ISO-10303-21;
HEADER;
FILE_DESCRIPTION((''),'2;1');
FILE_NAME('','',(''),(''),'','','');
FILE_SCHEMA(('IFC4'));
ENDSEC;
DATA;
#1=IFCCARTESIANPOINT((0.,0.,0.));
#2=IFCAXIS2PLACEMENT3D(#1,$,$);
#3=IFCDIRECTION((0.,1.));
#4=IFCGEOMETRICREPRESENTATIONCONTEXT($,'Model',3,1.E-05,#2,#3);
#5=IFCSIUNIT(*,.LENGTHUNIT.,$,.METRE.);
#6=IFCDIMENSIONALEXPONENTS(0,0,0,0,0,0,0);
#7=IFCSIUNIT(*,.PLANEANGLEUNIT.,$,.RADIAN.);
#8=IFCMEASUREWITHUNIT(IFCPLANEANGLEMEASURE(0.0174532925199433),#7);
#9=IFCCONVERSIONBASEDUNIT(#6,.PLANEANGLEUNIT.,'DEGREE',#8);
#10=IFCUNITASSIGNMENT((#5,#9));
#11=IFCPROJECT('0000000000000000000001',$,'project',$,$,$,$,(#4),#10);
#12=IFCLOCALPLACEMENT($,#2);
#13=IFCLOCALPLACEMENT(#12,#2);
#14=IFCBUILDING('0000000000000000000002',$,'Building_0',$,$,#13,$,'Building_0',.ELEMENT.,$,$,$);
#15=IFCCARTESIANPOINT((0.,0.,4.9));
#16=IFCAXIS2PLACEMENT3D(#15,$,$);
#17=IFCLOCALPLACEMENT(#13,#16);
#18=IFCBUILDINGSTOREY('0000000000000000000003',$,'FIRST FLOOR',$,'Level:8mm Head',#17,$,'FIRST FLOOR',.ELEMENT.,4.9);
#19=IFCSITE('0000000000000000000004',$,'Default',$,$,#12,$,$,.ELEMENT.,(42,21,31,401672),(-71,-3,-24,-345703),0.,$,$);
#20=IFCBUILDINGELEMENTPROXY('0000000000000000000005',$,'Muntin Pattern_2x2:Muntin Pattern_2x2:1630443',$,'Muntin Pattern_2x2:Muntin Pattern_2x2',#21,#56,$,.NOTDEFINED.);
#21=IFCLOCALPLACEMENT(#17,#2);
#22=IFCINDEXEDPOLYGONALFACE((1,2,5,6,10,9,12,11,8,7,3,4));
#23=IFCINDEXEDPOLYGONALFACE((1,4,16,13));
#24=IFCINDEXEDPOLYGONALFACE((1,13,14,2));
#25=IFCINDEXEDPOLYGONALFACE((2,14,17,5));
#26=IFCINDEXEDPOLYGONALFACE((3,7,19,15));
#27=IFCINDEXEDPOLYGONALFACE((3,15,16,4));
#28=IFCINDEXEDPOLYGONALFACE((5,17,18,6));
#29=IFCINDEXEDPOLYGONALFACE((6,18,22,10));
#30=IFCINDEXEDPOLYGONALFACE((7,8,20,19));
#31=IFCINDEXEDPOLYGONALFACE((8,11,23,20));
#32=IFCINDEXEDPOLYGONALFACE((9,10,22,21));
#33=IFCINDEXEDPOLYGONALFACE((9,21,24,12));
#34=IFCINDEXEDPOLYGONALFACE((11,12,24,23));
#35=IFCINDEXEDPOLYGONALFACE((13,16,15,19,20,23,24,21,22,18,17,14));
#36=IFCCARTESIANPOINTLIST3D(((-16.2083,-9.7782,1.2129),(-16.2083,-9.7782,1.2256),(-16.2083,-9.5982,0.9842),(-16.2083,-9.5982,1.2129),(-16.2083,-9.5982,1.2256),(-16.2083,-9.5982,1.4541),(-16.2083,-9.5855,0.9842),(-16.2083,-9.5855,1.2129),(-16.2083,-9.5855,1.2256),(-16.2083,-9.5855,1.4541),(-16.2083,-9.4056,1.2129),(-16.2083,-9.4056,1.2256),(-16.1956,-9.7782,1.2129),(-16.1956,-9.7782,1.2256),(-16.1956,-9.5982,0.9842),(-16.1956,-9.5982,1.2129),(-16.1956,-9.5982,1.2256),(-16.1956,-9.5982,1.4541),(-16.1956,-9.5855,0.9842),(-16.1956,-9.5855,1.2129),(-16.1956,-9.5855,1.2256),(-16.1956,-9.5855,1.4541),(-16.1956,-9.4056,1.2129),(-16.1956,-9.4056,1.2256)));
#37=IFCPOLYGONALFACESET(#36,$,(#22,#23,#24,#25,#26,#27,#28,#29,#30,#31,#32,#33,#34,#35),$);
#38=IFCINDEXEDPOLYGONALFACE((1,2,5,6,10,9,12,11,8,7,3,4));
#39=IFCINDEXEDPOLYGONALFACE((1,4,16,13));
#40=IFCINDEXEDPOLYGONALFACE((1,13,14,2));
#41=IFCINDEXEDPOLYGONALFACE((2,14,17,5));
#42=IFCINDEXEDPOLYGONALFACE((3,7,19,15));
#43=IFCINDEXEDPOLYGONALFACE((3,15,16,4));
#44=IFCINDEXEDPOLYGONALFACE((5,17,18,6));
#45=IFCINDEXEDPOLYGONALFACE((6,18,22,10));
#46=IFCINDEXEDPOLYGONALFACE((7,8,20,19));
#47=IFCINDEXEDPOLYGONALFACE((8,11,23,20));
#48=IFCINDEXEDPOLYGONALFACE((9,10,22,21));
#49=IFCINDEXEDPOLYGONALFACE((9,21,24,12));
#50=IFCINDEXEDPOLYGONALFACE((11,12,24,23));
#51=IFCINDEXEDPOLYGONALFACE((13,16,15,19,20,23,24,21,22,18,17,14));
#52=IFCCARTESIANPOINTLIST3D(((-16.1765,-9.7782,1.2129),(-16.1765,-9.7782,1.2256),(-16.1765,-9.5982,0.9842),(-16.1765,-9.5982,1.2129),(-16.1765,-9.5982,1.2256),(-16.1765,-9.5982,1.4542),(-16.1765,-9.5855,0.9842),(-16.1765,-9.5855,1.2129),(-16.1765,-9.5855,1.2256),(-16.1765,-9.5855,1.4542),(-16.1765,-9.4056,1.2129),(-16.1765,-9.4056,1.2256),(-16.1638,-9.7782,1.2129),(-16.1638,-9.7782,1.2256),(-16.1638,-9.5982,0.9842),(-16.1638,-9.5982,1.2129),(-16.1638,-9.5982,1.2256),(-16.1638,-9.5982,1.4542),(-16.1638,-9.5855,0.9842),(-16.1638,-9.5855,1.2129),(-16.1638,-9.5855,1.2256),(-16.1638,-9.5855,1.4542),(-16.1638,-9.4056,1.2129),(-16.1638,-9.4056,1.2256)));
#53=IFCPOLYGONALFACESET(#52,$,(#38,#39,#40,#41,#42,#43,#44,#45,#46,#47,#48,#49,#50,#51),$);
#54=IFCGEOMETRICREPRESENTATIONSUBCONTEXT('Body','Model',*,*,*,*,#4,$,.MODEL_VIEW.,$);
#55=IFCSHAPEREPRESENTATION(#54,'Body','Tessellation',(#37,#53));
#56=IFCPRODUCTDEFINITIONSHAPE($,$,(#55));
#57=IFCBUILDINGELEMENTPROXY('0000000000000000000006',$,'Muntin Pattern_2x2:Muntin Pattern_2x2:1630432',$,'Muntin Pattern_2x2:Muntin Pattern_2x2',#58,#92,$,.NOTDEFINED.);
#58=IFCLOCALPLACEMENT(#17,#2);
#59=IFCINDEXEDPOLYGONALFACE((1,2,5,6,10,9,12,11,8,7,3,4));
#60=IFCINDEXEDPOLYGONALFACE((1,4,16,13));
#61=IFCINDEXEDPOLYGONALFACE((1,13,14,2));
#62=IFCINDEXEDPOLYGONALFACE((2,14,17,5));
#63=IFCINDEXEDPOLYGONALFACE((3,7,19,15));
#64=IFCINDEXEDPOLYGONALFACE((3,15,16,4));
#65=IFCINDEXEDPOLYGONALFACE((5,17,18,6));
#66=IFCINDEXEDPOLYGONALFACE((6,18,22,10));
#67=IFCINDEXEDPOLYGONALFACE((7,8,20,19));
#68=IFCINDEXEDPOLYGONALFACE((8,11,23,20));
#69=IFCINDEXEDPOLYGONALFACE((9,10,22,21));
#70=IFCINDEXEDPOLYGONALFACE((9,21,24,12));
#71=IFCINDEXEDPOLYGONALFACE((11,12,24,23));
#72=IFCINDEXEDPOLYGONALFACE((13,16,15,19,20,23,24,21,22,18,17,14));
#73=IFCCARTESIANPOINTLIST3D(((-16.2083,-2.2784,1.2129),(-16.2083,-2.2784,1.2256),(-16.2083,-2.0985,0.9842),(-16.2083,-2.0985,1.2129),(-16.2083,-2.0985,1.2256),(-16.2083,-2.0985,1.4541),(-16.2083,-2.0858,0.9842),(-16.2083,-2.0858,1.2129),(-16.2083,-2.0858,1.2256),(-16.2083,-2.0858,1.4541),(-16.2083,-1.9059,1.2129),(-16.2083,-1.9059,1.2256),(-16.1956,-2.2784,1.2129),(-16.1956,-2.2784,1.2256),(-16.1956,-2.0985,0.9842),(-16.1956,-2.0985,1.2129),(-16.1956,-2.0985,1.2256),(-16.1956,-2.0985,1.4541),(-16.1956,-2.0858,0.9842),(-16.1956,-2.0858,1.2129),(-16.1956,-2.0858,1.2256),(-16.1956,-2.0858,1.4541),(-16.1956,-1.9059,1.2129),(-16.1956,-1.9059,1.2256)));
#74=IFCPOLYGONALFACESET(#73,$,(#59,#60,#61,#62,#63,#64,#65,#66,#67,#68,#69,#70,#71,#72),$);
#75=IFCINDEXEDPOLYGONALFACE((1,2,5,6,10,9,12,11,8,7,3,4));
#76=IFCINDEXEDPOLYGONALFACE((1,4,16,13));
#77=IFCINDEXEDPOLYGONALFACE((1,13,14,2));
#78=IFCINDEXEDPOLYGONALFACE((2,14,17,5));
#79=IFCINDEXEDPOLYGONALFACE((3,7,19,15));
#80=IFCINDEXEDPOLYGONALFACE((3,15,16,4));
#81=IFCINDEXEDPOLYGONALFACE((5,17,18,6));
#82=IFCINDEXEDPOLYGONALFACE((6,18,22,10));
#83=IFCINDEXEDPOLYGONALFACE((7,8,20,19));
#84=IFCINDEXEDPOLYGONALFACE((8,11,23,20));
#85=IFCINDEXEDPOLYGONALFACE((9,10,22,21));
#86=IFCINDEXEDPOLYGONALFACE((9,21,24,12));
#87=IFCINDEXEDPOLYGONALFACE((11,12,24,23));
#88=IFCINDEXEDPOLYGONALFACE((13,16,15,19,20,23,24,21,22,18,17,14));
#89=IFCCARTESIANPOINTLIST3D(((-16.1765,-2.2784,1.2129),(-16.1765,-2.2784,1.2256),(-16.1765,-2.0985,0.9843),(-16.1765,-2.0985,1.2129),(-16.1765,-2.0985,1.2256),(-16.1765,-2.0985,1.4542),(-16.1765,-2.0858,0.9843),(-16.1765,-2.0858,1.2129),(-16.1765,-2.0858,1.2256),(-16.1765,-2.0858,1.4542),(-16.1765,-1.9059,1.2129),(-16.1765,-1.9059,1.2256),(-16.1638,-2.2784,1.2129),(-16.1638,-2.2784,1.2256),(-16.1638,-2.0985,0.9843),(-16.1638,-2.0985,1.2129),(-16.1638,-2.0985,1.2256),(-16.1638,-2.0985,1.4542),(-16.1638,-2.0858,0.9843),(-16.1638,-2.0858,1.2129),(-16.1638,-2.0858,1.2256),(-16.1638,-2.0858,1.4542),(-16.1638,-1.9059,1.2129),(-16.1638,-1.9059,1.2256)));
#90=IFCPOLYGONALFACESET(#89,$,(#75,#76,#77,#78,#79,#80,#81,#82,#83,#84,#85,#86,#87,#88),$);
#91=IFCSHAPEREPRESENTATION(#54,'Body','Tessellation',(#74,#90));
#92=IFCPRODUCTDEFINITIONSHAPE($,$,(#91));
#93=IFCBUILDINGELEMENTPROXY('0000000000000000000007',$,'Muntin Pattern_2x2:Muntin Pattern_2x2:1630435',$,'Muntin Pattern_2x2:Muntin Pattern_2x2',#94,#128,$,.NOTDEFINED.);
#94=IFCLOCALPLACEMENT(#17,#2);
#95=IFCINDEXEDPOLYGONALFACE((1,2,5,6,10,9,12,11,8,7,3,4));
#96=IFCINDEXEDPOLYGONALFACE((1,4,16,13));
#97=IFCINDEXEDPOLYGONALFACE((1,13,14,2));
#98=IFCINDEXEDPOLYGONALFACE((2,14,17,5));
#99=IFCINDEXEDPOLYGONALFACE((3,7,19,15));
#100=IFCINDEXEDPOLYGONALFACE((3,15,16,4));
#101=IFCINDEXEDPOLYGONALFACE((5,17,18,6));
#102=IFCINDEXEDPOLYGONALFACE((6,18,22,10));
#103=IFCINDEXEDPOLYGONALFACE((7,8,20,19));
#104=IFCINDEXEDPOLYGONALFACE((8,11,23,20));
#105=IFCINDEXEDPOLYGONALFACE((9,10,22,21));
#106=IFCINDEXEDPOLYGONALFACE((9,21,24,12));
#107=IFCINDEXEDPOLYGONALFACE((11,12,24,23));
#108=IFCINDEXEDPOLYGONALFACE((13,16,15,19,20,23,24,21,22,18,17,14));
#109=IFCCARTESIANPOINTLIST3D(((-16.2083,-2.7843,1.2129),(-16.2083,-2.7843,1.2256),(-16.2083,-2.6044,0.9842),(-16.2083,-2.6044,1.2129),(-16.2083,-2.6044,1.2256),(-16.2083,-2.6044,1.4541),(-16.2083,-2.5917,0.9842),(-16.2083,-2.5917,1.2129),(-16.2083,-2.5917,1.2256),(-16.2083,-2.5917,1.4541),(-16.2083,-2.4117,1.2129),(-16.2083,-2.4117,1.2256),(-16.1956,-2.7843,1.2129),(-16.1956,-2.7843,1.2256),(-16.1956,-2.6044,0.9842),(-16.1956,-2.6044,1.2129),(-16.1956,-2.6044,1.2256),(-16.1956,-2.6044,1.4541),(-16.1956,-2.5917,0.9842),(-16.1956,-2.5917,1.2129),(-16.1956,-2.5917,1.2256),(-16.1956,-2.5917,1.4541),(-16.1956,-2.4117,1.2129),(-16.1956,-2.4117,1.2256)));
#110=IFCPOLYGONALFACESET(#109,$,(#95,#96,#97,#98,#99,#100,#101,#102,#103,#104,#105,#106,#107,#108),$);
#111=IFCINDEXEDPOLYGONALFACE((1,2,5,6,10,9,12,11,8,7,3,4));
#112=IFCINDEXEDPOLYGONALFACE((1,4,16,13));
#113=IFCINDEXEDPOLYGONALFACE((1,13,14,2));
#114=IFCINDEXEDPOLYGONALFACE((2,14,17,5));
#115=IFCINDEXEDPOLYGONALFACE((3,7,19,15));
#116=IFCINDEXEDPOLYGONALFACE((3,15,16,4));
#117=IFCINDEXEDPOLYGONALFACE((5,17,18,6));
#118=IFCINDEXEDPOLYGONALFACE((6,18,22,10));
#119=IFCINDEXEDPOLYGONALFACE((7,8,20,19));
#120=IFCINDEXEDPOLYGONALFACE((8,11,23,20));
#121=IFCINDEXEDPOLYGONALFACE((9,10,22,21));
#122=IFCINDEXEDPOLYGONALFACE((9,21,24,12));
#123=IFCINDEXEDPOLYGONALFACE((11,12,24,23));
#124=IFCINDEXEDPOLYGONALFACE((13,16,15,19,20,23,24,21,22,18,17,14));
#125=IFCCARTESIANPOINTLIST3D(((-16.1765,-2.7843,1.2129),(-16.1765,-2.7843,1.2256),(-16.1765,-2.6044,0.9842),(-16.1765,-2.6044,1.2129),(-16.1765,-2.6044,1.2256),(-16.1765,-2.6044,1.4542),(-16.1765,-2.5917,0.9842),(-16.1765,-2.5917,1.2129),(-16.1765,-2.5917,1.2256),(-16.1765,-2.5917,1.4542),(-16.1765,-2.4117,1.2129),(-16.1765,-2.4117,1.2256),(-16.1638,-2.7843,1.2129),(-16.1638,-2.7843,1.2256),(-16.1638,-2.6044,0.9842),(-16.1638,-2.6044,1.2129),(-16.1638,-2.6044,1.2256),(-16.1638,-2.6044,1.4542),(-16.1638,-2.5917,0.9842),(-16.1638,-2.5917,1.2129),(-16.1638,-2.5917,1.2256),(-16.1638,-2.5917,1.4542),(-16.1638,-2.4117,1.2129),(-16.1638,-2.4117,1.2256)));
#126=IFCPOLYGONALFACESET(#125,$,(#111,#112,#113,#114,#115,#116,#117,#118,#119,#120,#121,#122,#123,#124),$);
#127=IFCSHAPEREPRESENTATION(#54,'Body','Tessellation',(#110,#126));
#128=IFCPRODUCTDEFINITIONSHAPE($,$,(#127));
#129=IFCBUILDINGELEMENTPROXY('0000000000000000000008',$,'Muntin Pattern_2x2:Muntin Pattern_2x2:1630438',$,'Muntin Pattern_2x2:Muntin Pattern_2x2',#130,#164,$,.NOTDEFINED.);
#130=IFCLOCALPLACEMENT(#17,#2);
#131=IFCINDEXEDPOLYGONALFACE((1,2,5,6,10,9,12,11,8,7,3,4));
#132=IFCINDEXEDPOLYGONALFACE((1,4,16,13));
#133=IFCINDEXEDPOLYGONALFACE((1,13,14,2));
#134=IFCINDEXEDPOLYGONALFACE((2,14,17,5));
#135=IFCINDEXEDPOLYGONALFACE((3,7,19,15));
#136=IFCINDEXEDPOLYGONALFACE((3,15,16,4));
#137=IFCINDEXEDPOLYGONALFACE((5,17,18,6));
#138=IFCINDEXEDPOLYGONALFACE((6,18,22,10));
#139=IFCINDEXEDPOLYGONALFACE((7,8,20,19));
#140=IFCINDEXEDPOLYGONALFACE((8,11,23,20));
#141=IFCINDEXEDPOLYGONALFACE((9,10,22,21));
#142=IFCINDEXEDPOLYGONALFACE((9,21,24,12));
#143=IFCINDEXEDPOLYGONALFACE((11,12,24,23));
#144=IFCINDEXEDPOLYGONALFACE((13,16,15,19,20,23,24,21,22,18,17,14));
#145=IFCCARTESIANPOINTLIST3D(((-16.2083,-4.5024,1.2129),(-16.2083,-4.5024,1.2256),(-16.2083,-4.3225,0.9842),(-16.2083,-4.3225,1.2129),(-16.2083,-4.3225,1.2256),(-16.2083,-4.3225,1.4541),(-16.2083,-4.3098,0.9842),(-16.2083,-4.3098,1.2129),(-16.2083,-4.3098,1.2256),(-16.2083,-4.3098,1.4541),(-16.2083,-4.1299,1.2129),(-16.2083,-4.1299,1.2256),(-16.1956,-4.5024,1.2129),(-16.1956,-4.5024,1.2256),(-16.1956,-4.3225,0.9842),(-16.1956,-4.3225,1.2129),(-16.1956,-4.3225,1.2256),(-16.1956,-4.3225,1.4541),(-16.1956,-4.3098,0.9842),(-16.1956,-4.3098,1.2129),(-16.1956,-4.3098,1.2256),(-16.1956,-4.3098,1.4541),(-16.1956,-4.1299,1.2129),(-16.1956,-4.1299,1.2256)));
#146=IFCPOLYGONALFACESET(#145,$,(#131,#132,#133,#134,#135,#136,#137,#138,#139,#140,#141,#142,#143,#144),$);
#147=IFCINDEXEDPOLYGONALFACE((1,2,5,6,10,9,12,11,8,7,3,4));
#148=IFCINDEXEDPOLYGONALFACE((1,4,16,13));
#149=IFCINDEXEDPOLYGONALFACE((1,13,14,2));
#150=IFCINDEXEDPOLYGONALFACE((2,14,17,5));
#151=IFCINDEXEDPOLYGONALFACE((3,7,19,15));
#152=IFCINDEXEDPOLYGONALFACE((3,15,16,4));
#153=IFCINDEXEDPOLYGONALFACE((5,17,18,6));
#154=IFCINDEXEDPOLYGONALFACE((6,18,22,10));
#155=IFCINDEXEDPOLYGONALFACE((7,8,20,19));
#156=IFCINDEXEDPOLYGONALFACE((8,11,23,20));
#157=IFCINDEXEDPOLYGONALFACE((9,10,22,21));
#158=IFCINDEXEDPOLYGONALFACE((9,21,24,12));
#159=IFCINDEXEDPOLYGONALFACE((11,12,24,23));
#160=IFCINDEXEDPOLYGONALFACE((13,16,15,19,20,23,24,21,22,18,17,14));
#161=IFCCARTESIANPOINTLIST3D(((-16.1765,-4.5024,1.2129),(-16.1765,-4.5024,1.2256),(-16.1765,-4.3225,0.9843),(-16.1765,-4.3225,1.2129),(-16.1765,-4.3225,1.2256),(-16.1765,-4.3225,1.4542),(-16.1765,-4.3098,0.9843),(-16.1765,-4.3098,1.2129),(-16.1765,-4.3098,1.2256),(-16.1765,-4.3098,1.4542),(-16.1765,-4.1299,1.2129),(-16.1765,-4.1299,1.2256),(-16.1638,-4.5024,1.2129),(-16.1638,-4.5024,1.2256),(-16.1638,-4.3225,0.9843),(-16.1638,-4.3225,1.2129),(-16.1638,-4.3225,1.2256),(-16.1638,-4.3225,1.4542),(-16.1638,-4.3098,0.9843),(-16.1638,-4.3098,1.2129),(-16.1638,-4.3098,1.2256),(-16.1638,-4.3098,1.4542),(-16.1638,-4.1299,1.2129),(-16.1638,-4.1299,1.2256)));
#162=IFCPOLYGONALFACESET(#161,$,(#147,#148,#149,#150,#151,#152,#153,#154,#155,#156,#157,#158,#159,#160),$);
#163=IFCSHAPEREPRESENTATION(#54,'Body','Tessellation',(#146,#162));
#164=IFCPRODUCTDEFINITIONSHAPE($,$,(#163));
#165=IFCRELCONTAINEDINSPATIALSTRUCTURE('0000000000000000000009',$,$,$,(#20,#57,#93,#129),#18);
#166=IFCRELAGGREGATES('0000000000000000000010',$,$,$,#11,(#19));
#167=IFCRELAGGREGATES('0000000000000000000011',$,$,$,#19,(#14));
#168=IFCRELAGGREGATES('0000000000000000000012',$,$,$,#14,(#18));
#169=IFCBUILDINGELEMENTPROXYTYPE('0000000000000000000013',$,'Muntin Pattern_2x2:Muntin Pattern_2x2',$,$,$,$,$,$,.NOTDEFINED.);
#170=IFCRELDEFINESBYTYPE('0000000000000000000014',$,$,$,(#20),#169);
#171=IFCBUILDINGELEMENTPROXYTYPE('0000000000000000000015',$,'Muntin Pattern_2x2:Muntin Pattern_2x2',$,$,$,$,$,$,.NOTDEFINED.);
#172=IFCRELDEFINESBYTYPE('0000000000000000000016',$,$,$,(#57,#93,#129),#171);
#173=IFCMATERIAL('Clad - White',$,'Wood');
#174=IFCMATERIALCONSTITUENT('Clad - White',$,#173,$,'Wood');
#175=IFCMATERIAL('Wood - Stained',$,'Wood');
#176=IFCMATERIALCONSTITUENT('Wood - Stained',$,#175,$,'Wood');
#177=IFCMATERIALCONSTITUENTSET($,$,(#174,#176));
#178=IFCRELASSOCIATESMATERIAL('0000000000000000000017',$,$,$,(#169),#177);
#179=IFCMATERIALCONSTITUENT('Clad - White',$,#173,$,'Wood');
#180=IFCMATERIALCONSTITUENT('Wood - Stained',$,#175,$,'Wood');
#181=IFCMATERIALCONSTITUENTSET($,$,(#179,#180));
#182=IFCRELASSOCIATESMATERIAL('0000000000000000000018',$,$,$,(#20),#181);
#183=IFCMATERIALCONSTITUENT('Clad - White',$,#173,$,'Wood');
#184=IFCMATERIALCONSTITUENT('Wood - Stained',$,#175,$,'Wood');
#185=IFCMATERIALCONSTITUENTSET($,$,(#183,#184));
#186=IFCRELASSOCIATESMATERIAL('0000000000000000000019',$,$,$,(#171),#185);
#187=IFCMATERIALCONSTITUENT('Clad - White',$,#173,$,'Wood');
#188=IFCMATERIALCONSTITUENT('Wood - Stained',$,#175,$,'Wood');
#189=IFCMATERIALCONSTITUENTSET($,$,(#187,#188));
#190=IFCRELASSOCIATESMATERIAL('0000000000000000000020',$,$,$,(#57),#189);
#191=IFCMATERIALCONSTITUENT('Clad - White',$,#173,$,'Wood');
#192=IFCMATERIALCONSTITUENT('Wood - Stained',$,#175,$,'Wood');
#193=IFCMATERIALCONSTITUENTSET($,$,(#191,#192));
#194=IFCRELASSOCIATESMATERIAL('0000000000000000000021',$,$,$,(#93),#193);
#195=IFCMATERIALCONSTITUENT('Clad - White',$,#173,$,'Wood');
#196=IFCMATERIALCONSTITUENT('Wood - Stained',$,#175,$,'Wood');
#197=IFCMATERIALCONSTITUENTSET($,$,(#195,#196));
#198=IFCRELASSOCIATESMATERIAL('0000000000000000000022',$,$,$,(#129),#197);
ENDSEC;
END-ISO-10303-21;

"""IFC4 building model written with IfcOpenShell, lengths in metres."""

from ifc_helpers import new_model, entity, si_unit, converted_unit, direction, frame, origin, place, context, subcontext, project, spatial, indexed_curve, outline, extrude, source, transform, mapped, material, constituent, constituent_set, type_object, type_shapes, element, save


model = new_model("IFC4")

# Units and contexts
model_context = context("Model", 3, precision=1e-05, world=origin(), true_north=direction((0.0, 1.0)))
body_context = subcontext(model_context, "Body", "Model", "MODEL_VIEW")
ifc_project = project(units=[si_unit("LENGTHUNIT", "METRE"), converted_unit("PLANEANGLEUNIT", "DEGREE", entity("IfcPlaneAngleMeasure", 0.0174532925199433), si_unit("PLANEANGLEUNIT", "RADIAN"), dimensions=[0, 0, 0, 0, 0, 0, 0])], contexts=[model_context])

# Site, building, storey
site_placement = place(None, origin())
site = spatial("IfcSite", under=ifc_project, at=site_placement, Name="Default", CompositionType="ELEMENT", RefLatitude=(42, 21, 31, 401672), RefLongitude=(-71, -3, -24, -345703), RefElevation=0.0)
building_placement = place(site_placement, origin())
building = spatial("IfcBuilding", under=site, at=building_placement, Name="Building_0", LongName="Building_0", CompositionType="ELEMENT")
storey_placement = place(building_placement, frame((0.0, 0.0, 4.9)))
storey = spatial("IfcBuildingStorey", under=building, at=storey_placement, Name="FIRST FLOOR", ObjectType="Level:8mm Head", LongName="FIRST FLOOR", CompositionType="ELEMENT", Elevation=4.9)

# Shared definitions
ifc_material_1 = material(Name="Clad - White", Category="Wood")

# Building element proxies
ifc_material_2 = material(Name="Wood - Stained", Category="Wood")
ifc_constituent_1 = constituent(ifc_material_1, Name="Clad - White", Category="Wood")
ifc_constituent_2 = constituent(ifc_material_2, Name="Wood - Stained", Category="Wood")
ifc_constituent_set_1 = constituent_set(constituents=[ifc_constituent_1, ifc_constituent_2])
building_element_proxy_type_1 = type_object("IfcBuildingElementProxyType", Name="Muntin Pattern_2x2:Muntin Pattern_2x2", PredefinedType="NOTDEFINED", material=ifc_constituent_set_1)
shared_shape_1 = source(origin(), body_context, "Body", "SweptSolid", [
    extrude(outline(indexed_curve([(0.0064, -0.0064), (0.2349, -0.0064), (0.2349, 0.0063), (0.0064, 0.0063), (0.0064, 0.1863), (-0.0063, 0.1863), (-0.0063, 0.0063), (-0.235, 0.0063), (-0.235, -0.0064), (-0.0063, -0.0064), (-0.0063, -0.1863), (0.0064, -0.1863), (0.0064, -0.0064)], self_intersect=False)), frame((0.0, 0.0095, 0.235), z_axis=(0.0, 1.0, 0.0), x_axis=(0.0, 0.0, 1.0)), (0.0, 0.0, 1.0), 0.0127),
    extrude(outline(indexed_curve([(0.0064, -0.0064), (0.235, -0.0064), (0.235, 0.0063), (0.0064, 0.0063), (0.0064, 0.1863), (-0.0063, 0.1863), (-0.0063, 0.0063), (-0.235, 0.0063), (-0.235, -0.0064), (-0.0063, -0.0064), (-0.0063, -0.1863), (0.0064, -0.1863), (0.0064, -0.0064)], self_intersect=False)), frame((0.0, -0.0222, 0.235), z_axis=(0.0, 1.0, 0.0), x_axis=(0.0, 0.0, 1.0)), (0.0, 0.0, 1.0), 0.0127),
])
type_shapes(building_element_proxy_type_1, [shared_shape_1])
ifc_constituent_3 = constituent(ifc_material_1, Name="Clad - White", Category="Wood")
ifc_constituent_4 = constituent(ifc_material_2, Name="Wood - Stained", Category="Wood")
ifc_constituent_set_2 = constituent_set(constituents=[ifc_constituent_3, ifc_constituent_4])
proxy_1_placement = place(storey_placement, frame((-16.1861, -9.5919, 0.9842), z_axis=(0.0, 0.0, 1.0), x_axis=(0.0, 1.0, 0.0)))
element("IfcBuildingElementProxy", 1, at=proxy_1_placement, inside=storey, type_object=building_element_proxy_type_1, material=ifc_constituent_set_2, Name="Muntin Pattern_2x2:Muntin Pattern_2x2:1630443", ObjectType="Muntin Pattern_2x2:Muntin Pattern_2x2", PredefinedType="NOTDEFINED", context=body_context, shape_type="MappedRepresentation", body=[
    mapped(shared_shape_1, transform((0.0, 0.0, 0.0), scale=1.0)),
])
ifc_constituent_5 = constituent(ifc_material_1, Name="Clad - White", Category="Wood")
ifc_constituent_6 = constituent(ifc_material_2, Name="Wood - Stained", Category="Wood")
ifc_constituent_set_3 = constituent_set(constituents=[ifc_constituent_5, ifc_constituent_6])
ifc_constituent_7 = constituent(ifc_material_1, Name="Clad - White", Category="Wood")
ifc_constituent_8 = constituent(ifc_material_2, Name="Wood - Stained", Category="Wood")
ifc_constituent_set_4 = constituent_set(constituents=[ifc_constituent_7, ifc_constituent_8])
building_element_proxy_type_2 = type_object("IfcBuildingElementProxyType", Name="Muntin Pattern_2x2:Muntin Pattern_2x2", PredefinedType="NOTDEFINED", material=ifc_constituent_set_4)
shared_shape_2 = source(origin(), body_context, "Body", "SweptSolid", [
    extrude(outline(indexed_curve([(0.0064, -0.0064), (0.2349, -0.0064), (0.2349, 0.0063), (0.0064, 0.0063), (0.0064, 0.1863), (-0.0063, 0.1863), (-0.0063, 0.0063), (-0.235, 0.0063), (-0.235, -0.0064), (-0.0063, -0.0064), (-0.0063, -0.1863), (0.0064, -0.1863), (0.0064, -0.0064)], self_intersect=False)), frame((0.0, -0.0222, 0.2349), z_axis=(0.0, 1.0, 0.0), x_axis=(0.0, 0.0, 1.0)), (0.0, 0.0, 1.0), 0.0127),
    extrude(outline(indexed_curve([(0.0064, -0.0064), (0.235, -0.0064), (0.235, 0.0063), (0.0064, 0.0063), (0.0064, 0.1863), (-0.0063, 0.1863), (-0.0063, 0.0063), (-0.235, 0.0063), (-0.235, -0.0064), (-0.0063, -0.0064), (-0.0063, -0.1863), (0.0064, -0.1863), (0.0064, -0.0064)], self_intersect=False)), frame((0.0, 0.0095, 0.235), z_axis=(0.0, 1.0, 0.0), x_axis=(0.0, 0.0, 1.0)), (0.0, 0.0, 1.0), 0.0127),
])
type_shapes(building_element_proxy_type_2, [shared_shape_2])
proxy_2_placement = place(storey_placement, frame((-16.1861, -2.0921, 0.9843), z_axis=(0.0, 0.0, 1.0), x_axis=(0.0, -1.0, 0.0)))
element("IfcBuildingElementProxy", 2, at=proxy_2_placement, inside=storey, type_object=building_element_proxy_type_2, material=ifc_constituent_set_3, Name="Muntin Pattern_2x2:Muntin Pattern_2x2:1630432", ObjectType="Muntin Pattern_2x2:Muntin Pattern_2x2", PredefinedType="NOTDEFINED", context=body_context, shape_type="MappedRepresentation", body=[
    mapped(shared_shape_2, transform((0.0, 0.0, 0.0), scale=1.0)),
])
ifc_constituent_9 = constituent(ifc_material_1, Name="Clad - White", Category="Wood")
ifc_constituent_10 = constituent(ifc_material_2, Name="Wood - Stained", Category="Wood")
ifc_constituent_set_5 = constituent_set(constituents=[ifc_constituent_9, ifc_constituent_10])
proxy_3_placement = place(storey_placement, frame((-16.1861, -2.598, 0.9842), z_axis=(0.0, 0.0, 1.0), x_axis=(0.0, -1.0, 0.0)))
element("IfcBuildingElementProxy", 3, at=proxy_3_placement, inside=storey, type_object=building_element_proxy_type_2, material=ifc_constituent_set_5, Name="Muntin Pattern_2x2:Muntin Pattern_2x2:1630435", ObjectType="Muntin Pattern_2x2:Muntin Pattern_2x2", PredefinedType="NOTDEFINED", context=body_context, shape_type="MappedRepresentation", body=[
    mapped(shared_shape_2, transform((0.0, 0.0, 0.0), scale=1.0)),
])
ifc_constituent_11 = constituent(ifc_material_1, Name="Clad - White", Category="Wood")
ifc_constituent_12 = constituent(ifc_material_2, Name="Wood - Stained", Category="Wood")
ifc_constituent_set_6 = constituent_set(constituents=[ifc_constituent_11, ifc_constituent_12])
proxy_4_placement = place(storey_placement, frame((-16.1861, -4.3161, 0.9843), z_axis=(0.0, 0.0, 1.0), x_axis=(0.0, -1.0, 0.0)))
element("IfcBuildingElementProxy", 4, at=proxy_4_placement, inside=storey, type_object=building_element_proxy_type_2, material=ifc_constituent_set_6, Name="Muntin Pattern_2x2:Muntin Pattern_2x2:1630438", ObjectType="Muntin Pattern_2x2:Muntin Pattern_2x2", PredefinedType="NOTDEFINED", context=body_context, shape_type="MappedRepresentation", body=[
    mapped(shared_shape_2, transform((0.0, 0.0, 0.0), scale=1.0)),
])

save(model, "model.ifc")
